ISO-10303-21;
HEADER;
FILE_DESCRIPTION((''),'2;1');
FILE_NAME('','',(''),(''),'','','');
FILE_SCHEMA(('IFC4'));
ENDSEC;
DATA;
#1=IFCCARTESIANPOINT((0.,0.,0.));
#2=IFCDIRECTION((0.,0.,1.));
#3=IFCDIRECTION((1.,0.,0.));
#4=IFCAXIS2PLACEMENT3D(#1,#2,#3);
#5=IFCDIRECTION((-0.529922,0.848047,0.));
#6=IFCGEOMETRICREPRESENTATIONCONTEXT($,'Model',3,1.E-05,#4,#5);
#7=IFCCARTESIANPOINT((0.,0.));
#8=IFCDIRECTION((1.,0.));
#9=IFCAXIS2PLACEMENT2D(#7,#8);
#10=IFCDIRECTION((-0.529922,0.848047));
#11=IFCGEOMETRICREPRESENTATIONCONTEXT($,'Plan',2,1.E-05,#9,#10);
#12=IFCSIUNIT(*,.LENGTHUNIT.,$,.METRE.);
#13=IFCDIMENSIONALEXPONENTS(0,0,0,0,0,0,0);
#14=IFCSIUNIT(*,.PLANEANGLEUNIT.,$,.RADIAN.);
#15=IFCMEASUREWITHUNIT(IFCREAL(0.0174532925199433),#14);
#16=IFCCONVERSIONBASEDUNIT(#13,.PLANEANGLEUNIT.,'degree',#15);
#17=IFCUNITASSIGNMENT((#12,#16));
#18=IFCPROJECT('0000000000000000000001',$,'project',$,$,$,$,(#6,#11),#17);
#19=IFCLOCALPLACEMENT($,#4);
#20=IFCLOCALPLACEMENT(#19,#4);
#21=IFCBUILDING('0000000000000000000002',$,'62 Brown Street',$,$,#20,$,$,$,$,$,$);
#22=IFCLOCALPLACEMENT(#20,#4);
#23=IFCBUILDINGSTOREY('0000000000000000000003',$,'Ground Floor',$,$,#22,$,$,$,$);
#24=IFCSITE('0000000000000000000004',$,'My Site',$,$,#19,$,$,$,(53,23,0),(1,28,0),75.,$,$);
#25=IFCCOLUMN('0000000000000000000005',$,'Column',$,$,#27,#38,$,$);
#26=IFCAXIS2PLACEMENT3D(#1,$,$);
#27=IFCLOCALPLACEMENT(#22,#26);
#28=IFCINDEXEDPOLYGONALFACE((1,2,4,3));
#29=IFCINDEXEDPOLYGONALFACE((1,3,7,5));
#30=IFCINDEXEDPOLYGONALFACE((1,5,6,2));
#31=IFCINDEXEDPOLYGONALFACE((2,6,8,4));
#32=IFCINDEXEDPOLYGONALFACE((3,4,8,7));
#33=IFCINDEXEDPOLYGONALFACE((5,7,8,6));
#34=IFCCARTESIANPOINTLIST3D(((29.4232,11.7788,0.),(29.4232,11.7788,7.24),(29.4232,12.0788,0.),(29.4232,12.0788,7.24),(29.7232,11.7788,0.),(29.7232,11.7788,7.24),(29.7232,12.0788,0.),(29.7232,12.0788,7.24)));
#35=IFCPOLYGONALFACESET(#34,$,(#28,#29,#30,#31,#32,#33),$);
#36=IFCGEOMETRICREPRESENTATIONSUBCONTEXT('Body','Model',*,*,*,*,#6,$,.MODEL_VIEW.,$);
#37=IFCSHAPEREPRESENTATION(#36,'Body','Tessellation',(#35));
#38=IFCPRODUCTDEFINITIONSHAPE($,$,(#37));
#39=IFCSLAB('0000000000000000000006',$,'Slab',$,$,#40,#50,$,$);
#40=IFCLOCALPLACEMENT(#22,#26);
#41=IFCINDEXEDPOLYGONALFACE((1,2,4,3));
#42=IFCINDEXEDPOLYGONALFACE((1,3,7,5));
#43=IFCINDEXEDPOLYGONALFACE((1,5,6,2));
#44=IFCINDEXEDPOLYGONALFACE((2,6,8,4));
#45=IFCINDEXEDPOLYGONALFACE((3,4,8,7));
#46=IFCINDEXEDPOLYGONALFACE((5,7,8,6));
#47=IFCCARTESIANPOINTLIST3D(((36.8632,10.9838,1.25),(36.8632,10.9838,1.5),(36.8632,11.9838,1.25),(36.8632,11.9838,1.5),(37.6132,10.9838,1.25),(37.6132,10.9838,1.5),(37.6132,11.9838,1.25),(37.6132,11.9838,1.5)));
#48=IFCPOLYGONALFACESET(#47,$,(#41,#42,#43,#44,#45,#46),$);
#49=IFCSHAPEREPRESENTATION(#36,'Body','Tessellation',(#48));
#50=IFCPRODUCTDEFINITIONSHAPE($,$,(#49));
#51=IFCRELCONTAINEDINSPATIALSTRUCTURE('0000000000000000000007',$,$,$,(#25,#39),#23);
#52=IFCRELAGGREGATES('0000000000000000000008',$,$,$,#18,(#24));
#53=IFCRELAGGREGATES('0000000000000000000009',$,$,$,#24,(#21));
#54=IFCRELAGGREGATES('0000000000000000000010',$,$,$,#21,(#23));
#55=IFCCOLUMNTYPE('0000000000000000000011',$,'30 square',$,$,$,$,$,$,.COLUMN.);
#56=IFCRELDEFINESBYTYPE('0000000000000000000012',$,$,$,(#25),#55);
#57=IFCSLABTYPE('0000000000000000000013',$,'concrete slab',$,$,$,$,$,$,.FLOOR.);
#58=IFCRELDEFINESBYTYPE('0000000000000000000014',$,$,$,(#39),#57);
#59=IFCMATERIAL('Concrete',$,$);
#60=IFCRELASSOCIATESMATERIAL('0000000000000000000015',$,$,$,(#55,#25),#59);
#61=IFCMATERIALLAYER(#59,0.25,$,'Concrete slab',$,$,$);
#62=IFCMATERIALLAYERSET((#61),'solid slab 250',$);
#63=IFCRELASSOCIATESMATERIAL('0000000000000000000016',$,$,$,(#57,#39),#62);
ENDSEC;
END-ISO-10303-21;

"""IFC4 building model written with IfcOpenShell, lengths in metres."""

from ifc_helpers import new_model, entity, si_unit, converted_unit, direction, frame, origin_with_axes, origin_2d_with_axis, place, context, subcontext, project, spatial, line, indexed_curve, rectangle, outline, extrude, material, layer, layer_set, layer_usage, material_profile, profile_set, profile_usage, type_object, element, save


model = new_model("IFC4")

# Units and contexts
model_context = context("Model", 3, precision=1e-05, world=origin_with_axes(), true_north=direction((-0.529922, 0.848047, 0.0)))
plan_context = context("Plan", 2, precision=1e-05, world=origin_2d_with_axis(), true_north=direction((-0.529922, 0.848047)))
body_context_1 = subcontext(model_context, "Body", "Model", "MODEL_VIEW")
ifc_project = project(units=[si_unit("LENGTHUNIT", "METRE"), converted_unit("PLANEANGLEUNIT", "degree", entity("IfcReal", 0.0174532925199433), si_unit("PLANEANGLEUNIT", "RADIAN"), dimensions=[0, 0, 0, 0, 0, 0, 0])], contexts=[model_context, plan_context])

# Site, building, storey
site_placement = place(None, origin_with_axes())
site = spatial("IfcSite", under=ifc_project, at=site_placement, Name="My Site", RefLatitude=(53, 23, 0), RefLongitude=(1, 28, 0), RefElevation=75.0)
building_placement = place(site_placement, origin_with_axes())
building = spatial("IfcBuilding", under=site, at=building_placement, Name="62 Brown Street")
storey_placement = place(building_placement, origin_with_axes())
storey = spatial("IfcBuildingStorey", under=building, at=storey_placement, Name="Ground Floor")

# Column
ifc_material_1 = material(Name="Concrete")
ifc_material_profile_1 = material_profile(ifc_material_1, rectangle(XDim=0.3, YDim=0.3))
ifc_profile_set_1 = profile_set([ifc_material_profile_1])
ifc_profile_usage_1 = profile_usage(ifc_profile_set_1, cardinal=5)
column_type = type_object("IfcColumnType", Name="30 square", PredefinedType="COLUMN", material=ifc_profile_set_1)
column_placement = place(storey_placement, frame((29.5732, 11.9288, 0.0), z_axis=(0.0, 0.0, 1.0), x_axis=(1.0, 0.0, 0.0)))
element("IfcColumn", 1, at=column_placement, inside=storey, type_object=column_type, material=ifc_profile_usage_1, Name="Column", context=body_context_1, shape_type="SweptSolid", body=[
    extrude(rectangle(XDim=0.3, YDim=0.3), origin_with_axes(), (0.0, 0.0, 1.0), 7.24),
])

# Slab
ifc_layer_1 = layer(ifc_material_1, 0.25, Name="Concrete slab")
ifc_layer_set_1 = layer_set([ifc_layer_1], Name="solid slab 250")
slab_type = type_object("IfcSlabType", Name="concrete slab", PredefinedType="FLOOR", material=ifc_layer_set_1)
ifc_layer_usage_1 = layer_usage(ifc_layer_set_1, "AXIS3", "POSITIVE", 0.0)
slab_1_placement = place(storey_placement, frame((36.8632, 10.9838, 1.25), z_axis=(0.0, 0.0, 1.0), x_axis=(1.0, 0.0, 0.0)))
element("IfcSlab", 2, at=slab_1_placement, inside=storey, type_object=slab_type, material=ifc_layer_usage_1, Name="Slab", context=body_context_1, shape_type="SweptSolid", body=[
    extrude(outline(indexed_curve([(0.0, 0.0), (0.75, 0.0), (0.75, 1.0), (0.0, 1.0)], segments=[line(4, 1), line(1, 2), line(2, 3), line(3, 4)], self_intersect=False)), None, (0.0, 0.0, 1.0), 0.25),
])

save(model, "model.ifc")
